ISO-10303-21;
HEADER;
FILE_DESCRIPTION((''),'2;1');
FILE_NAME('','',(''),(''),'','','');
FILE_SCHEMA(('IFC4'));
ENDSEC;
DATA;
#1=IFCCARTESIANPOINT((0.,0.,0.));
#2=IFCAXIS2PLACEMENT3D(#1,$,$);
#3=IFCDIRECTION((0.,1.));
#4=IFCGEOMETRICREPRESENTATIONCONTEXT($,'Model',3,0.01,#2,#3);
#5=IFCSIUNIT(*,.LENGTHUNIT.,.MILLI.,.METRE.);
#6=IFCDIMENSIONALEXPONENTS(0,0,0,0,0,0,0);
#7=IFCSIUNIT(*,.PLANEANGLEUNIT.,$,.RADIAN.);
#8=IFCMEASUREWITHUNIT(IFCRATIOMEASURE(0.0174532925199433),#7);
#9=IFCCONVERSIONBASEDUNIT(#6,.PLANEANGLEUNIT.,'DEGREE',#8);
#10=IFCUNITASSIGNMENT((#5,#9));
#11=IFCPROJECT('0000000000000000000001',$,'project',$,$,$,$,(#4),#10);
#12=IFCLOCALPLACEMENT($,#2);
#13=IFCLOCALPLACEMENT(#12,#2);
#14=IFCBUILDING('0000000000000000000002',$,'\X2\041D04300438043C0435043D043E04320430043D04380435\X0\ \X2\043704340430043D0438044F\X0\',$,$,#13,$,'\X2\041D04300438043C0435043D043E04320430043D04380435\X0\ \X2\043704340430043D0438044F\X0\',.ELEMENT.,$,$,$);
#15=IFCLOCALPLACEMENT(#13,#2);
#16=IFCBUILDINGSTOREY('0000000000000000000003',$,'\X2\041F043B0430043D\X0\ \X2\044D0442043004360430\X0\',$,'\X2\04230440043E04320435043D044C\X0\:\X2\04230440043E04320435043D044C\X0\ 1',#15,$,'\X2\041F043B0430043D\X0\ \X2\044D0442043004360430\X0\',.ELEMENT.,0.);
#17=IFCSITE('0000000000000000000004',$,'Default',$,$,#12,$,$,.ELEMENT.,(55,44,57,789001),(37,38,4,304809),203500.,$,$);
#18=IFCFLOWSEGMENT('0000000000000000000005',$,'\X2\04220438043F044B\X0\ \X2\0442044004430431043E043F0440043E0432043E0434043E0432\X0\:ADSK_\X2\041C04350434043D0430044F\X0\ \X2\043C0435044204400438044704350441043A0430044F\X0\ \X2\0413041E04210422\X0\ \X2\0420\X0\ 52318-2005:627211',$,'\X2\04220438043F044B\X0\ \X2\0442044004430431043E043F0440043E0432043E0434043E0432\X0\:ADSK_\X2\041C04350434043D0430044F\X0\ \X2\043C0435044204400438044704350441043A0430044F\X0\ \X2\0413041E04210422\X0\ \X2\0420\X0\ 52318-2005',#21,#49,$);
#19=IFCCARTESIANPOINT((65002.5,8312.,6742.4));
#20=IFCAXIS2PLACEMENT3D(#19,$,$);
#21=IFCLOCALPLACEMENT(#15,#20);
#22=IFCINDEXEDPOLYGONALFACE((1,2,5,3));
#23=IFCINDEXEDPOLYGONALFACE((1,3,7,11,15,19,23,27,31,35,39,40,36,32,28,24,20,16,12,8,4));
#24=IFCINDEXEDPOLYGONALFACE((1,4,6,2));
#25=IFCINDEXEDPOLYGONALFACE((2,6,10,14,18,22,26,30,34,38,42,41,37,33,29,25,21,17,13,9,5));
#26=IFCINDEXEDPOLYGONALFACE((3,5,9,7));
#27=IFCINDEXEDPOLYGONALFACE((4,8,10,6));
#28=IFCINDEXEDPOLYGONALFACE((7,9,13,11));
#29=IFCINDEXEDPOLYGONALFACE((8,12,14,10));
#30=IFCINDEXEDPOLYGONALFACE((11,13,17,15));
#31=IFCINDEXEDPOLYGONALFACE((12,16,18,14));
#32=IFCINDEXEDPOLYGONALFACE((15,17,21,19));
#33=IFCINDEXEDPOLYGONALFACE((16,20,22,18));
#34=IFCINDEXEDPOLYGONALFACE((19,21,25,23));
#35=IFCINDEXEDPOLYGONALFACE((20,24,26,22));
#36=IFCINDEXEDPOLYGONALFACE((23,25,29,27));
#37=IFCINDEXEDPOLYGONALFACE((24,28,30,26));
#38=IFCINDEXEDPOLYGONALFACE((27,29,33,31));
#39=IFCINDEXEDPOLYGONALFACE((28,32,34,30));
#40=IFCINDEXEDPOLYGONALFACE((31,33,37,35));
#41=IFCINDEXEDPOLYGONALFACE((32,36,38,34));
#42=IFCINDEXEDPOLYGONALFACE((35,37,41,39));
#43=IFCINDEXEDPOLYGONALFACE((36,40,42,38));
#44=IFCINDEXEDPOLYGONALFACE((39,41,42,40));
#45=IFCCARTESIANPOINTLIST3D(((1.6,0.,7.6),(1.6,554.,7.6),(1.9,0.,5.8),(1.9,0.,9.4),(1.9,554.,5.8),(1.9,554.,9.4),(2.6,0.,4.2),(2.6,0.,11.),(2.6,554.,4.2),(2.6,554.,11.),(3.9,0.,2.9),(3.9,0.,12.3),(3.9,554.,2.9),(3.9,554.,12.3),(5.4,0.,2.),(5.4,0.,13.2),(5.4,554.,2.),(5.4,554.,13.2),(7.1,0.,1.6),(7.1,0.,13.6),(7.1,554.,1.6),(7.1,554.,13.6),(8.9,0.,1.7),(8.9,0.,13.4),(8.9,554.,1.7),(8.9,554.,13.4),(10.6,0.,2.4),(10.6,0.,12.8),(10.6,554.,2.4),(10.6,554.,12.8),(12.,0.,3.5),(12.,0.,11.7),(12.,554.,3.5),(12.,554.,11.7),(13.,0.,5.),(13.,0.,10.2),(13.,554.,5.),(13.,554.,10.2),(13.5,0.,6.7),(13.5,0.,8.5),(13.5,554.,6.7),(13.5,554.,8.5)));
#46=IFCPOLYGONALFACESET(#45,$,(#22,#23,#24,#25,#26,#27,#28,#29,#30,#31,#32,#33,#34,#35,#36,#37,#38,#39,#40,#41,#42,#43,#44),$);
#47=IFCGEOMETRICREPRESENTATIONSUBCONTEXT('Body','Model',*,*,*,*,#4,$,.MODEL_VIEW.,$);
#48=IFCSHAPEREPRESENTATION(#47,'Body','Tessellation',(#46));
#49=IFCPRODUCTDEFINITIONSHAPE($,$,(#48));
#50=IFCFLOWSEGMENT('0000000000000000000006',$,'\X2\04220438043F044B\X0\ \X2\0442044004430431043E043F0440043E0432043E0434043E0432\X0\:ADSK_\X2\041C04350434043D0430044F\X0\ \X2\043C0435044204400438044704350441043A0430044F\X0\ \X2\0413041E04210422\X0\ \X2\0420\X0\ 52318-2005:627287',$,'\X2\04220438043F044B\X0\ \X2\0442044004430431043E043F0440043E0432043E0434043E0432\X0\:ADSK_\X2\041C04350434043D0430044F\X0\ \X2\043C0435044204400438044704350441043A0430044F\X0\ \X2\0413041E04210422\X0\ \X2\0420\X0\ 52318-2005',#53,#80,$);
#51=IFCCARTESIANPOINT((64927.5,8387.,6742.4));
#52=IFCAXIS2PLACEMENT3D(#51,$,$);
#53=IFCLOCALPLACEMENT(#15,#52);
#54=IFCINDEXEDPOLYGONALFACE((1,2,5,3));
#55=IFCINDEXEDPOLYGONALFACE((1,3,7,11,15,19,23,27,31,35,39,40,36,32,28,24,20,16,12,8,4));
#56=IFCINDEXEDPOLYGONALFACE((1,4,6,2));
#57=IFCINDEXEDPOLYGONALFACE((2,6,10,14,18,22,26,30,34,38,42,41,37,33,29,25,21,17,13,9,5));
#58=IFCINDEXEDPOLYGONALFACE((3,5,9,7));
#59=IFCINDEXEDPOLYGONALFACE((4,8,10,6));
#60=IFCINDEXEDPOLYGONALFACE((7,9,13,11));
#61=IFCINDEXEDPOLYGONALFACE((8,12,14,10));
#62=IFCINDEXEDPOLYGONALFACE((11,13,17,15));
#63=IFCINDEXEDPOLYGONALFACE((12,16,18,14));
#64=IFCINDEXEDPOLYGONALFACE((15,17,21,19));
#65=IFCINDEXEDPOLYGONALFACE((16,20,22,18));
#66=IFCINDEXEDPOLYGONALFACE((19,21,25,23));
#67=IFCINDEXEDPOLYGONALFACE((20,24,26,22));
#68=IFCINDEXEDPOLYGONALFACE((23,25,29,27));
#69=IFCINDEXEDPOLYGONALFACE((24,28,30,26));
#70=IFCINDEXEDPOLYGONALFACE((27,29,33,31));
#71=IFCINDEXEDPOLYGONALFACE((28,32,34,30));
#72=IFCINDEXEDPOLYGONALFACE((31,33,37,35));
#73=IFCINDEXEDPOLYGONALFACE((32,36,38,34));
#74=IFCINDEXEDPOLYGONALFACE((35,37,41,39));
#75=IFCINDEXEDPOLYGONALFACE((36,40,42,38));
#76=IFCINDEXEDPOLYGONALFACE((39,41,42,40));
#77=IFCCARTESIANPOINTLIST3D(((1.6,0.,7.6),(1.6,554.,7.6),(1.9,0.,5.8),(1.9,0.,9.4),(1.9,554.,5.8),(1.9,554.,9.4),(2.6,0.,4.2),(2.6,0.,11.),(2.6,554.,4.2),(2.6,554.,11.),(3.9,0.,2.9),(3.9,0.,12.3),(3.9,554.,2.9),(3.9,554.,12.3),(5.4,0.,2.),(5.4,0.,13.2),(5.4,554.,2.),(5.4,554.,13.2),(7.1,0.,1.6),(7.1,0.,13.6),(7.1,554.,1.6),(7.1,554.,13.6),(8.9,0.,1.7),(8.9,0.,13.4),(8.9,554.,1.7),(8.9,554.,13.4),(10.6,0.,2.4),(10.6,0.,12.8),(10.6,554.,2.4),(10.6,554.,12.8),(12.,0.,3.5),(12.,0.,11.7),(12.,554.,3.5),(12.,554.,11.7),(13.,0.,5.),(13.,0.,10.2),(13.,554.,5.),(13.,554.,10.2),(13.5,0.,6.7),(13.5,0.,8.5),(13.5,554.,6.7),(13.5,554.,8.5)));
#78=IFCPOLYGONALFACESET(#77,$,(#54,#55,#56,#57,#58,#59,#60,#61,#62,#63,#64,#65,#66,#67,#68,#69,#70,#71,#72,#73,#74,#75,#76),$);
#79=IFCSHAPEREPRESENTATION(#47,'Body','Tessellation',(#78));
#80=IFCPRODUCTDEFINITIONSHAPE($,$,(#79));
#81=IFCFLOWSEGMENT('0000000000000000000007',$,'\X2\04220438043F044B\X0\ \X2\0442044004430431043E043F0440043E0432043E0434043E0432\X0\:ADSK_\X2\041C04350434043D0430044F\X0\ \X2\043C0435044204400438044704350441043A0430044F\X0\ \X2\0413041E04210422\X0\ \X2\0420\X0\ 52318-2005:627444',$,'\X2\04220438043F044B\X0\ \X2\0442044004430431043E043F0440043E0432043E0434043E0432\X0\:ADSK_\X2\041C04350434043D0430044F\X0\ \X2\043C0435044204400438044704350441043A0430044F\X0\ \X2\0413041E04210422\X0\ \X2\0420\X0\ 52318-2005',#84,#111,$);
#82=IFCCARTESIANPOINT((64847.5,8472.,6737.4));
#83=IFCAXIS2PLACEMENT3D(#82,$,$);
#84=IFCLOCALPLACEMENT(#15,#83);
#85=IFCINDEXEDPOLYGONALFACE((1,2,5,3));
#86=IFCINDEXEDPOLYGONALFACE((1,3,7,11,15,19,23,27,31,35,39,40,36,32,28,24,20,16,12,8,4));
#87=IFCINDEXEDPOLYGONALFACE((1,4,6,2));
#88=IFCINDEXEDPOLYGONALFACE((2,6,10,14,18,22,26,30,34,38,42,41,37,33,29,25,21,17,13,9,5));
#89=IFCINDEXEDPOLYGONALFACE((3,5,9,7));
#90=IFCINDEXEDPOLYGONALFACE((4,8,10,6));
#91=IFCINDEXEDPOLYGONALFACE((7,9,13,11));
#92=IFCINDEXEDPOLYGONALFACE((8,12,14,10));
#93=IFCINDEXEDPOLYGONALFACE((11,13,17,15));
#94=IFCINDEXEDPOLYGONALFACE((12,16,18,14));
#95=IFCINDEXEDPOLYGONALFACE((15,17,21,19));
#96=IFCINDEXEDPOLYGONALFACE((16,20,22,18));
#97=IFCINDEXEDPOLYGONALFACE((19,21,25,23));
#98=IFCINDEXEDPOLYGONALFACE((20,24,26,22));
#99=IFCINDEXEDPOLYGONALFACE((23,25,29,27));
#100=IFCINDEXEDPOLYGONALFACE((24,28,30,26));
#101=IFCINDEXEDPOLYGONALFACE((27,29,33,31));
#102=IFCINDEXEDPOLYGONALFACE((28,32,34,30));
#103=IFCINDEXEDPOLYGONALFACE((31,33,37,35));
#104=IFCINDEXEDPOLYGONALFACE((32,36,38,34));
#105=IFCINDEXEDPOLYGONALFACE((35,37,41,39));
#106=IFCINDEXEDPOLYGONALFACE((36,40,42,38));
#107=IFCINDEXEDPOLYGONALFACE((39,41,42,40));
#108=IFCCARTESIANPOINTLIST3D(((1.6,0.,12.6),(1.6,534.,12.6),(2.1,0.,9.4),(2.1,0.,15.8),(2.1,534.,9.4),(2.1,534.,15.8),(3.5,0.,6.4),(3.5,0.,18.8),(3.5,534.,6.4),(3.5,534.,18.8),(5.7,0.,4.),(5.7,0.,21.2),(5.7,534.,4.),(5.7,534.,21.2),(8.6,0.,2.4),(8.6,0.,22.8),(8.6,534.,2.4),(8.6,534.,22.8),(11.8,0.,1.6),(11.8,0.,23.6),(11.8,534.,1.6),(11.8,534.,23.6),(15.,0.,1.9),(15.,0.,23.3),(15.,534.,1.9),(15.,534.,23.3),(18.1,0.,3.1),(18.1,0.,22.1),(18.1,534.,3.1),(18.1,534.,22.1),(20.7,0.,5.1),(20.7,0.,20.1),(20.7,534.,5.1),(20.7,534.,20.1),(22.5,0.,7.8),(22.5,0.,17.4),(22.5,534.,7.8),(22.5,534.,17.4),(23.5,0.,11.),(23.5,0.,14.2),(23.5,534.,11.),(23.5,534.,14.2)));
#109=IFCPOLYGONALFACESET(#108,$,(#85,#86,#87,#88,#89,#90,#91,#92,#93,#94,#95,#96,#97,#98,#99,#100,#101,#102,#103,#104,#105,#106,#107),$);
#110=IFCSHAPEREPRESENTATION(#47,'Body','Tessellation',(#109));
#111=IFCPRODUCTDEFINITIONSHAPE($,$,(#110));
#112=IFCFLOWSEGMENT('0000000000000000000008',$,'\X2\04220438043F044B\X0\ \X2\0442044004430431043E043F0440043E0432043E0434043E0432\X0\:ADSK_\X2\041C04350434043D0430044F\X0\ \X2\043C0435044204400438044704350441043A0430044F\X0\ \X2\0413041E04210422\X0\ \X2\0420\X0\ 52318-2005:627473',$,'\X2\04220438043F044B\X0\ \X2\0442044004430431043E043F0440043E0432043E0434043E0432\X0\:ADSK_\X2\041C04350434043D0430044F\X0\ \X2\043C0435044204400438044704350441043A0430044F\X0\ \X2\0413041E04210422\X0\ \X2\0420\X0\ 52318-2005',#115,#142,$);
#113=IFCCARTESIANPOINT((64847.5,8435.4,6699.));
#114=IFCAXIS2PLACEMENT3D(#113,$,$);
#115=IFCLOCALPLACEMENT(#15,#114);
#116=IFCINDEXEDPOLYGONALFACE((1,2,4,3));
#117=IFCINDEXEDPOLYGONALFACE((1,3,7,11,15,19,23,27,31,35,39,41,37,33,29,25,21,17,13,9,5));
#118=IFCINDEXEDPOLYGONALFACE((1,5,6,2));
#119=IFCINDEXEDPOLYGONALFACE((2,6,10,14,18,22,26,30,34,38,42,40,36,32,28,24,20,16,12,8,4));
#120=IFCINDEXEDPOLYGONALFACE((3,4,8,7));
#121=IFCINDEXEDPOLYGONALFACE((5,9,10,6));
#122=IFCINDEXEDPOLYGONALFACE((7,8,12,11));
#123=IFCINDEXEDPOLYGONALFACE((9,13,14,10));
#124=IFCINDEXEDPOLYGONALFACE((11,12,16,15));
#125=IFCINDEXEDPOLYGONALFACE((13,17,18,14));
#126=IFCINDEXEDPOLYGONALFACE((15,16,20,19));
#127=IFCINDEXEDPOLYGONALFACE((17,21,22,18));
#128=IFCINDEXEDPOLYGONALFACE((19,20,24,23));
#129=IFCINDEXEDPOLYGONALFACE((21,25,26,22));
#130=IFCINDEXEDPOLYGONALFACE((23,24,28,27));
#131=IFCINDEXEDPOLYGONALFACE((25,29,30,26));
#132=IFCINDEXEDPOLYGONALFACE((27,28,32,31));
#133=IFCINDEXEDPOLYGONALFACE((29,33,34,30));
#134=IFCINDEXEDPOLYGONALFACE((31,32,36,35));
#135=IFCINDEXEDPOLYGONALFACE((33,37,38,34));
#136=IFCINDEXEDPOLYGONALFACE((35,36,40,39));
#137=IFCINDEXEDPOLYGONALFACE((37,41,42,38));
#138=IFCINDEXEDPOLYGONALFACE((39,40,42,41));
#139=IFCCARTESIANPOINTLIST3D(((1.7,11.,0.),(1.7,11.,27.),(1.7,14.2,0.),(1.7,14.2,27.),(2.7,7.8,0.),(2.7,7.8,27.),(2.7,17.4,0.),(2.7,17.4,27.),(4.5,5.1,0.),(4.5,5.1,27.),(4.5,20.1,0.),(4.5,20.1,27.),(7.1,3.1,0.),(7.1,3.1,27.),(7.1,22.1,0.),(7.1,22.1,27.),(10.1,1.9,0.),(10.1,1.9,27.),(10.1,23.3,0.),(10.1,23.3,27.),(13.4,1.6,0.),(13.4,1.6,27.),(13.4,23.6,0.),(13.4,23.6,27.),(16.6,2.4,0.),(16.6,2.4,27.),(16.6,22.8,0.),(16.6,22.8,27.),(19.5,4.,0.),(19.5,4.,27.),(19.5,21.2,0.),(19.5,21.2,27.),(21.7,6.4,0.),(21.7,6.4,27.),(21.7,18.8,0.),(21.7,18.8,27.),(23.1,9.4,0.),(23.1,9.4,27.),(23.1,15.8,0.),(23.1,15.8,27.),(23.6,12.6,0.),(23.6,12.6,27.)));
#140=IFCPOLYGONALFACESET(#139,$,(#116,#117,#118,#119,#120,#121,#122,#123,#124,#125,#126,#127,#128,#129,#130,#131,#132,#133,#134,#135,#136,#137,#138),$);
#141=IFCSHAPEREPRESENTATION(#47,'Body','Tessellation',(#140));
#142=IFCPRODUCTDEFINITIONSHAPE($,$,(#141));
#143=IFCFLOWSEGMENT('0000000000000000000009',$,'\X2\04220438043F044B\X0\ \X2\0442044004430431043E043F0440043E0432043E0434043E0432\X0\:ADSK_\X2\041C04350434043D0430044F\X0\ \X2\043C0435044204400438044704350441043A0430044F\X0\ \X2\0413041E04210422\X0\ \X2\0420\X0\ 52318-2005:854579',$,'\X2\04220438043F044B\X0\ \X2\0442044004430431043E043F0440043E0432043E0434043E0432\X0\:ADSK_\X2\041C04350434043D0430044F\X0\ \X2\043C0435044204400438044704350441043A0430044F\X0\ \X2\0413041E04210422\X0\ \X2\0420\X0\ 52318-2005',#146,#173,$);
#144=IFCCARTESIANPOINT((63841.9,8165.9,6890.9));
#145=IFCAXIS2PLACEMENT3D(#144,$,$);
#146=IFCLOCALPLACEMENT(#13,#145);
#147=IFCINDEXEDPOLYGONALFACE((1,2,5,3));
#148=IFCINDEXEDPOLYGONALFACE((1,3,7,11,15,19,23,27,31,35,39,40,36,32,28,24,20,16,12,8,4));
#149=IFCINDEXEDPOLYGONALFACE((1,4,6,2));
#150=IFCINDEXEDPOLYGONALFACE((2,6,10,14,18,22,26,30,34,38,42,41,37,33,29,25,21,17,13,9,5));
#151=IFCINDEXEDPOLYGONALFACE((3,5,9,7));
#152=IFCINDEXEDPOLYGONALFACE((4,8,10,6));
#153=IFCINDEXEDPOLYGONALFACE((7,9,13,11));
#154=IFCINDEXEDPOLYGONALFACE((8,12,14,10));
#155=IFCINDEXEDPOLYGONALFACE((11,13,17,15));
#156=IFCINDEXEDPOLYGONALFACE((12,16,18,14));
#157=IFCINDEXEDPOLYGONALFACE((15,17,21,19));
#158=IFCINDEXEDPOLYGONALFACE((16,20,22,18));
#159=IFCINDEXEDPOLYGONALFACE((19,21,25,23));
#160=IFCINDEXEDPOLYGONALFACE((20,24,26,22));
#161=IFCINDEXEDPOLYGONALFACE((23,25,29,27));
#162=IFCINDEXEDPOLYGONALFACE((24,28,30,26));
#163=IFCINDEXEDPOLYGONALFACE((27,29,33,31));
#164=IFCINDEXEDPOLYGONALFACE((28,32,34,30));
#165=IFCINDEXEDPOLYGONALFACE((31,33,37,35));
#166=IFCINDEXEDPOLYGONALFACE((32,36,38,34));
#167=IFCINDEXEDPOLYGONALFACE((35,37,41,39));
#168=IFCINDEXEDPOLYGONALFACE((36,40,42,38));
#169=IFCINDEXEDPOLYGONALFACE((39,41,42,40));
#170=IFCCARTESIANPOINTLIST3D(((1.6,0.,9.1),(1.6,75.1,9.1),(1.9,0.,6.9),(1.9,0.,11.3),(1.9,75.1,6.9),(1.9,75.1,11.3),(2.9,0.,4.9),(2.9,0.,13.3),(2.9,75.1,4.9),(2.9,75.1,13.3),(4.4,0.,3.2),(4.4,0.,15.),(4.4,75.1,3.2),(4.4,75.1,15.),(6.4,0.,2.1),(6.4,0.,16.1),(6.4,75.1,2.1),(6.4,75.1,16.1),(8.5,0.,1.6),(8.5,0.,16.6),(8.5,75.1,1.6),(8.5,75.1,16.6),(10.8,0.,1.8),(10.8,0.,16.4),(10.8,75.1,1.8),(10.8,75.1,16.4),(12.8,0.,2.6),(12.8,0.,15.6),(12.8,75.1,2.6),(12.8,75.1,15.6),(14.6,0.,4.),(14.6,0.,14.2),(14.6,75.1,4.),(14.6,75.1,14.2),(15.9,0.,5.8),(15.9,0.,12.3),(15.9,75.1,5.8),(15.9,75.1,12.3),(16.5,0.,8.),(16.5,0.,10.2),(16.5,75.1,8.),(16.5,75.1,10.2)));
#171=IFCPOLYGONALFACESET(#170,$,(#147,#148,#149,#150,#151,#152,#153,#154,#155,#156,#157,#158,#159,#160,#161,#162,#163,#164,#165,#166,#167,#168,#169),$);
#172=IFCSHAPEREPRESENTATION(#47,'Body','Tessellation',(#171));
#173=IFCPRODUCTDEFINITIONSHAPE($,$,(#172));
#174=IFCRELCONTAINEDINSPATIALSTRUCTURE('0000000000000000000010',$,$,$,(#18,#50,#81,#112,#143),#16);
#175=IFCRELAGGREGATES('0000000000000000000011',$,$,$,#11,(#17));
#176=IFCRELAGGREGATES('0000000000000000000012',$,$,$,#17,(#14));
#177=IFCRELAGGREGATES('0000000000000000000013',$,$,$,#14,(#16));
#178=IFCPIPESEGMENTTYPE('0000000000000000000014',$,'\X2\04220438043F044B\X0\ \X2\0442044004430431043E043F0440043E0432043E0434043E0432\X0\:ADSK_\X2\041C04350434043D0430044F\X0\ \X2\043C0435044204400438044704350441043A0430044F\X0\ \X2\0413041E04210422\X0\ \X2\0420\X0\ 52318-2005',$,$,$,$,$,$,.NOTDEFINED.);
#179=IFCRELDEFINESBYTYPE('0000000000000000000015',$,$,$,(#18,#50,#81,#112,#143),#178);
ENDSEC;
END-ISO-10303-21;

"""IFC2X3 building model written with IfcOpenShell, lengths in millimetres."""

from ifc_helpers import new_model, entity, si_unit, converted_unit, direction, frame, frame_2d, origin, origin_2d_with_axis, place, context, subcontext, project, spatial, circle, extrude, type_object, element, save


model = new_model("IFC2X3")

# Units and contexts
model_context = context("Model", 3, precision=0.01, world=origin(), true_north=direction((0.0, 1.0)))
body_context = subcontext(model_context, "Body", "Model", "MODEL_VIEW")
ifc_project = project(units=[si_unit("LENGTHUNIT", "METRE", prefix="MILLI"), converted_unit("PLANEANGLEUNIT", "DEGREE", entity("IfcRatioMeasure", 0.0174532925199433), si_unit("PLANEANGLEUNIT", "RADIAN"), dimensions=[0, 0, 0, 0, 0, 0, 0])], contexts=[model_context])

# Site, building, storey
site_placement = place(None, frame((0.0, 0.0, 0.0)))
site = spatial("IfcSite", under=ifc_project, at=site_placement, Name="Default", CompositionType="ELEMENT", RefLatitude=(55, 44, 57, 789001), RefLongitude=(37, 38, 4, 304809), RefElevation=203500.0)
building_placement = place(site_placement, origin())
building = spatial("IfcBuilding", under=site, at=building_placement, Name="Наименование здания", LongName="Наименование здания", CompositionType="ELEMENT")
storey_placement = place(building_placement, origin())
storey = spatial("IfcBuildingStorey", under=building, at=storey_placement, Name="План этажа", ObjectType="Уровень:Уровень 1", LongName="План этажа", CompositionType="ELEMENT", Elevation=0.0)

# Flow segments
pipe_segment_type = type_object("IfcPipeSegmentType", Name="Типы трубопроводов:ADSK_Медная метрическая ГОСТ Р 52318-2005", PredefinedType="NOTDEFINED")
flow_segment_1_placement = place(storey_placement, frame((65002.5, 8312.0, 6742.4)))
element("IfcFlowSegment", 1, at=flow_segment_1_placement, inside=storey, type_object=pipe_segment_type, Name="Типы трубопроводов:ADSK_Медная метрическая ГОСТ Р 52318-2005:627211", ObjectType="Типы трубопроводов:ADSK_Медная метрическая ГОСТ Р 52318-2005", context=body_context, shape_type="SweptSolid", body=[
    extrude(circle(Radius=6.0, at=frame_2d((0.0, 0.0), x_axis=(1.0, 0.0))), frame((7.6, 0.0, 7.6), z_axis=(0.0, 1.0, 0.0), x_axis=(-1.0, 0.0, 0.0)), (0.0, 0.0, 1.0), 554.0),
])
flow_segment_2_placement = place(storey_placement, frame((64927.5, 8387.0, 6742.4)))
element("IfcFlowSegment", 2, at=flow_segment_2_placement, inside=storey, type_object=pipe_segment_type, Name="Типы трубопроводов:ADSK_Медная метрическая ГОСТ Р 52318-2005:627287", ObjectType="Типы трубопроводов:ADSK_Медная метрическая ГОСТ Р 52318-2005", context=body_context, shape_type="SweptSolid", body=[
    extrude(circle(Radius=6.0, at=origin_2d_with_axis()), frame((7.6, 0.0, 7.6), z_axis=(0.0, 1.0, 0.0), x_axis=(-1.0, 0.0, 0.0)), (0.0, 0.0, 1.0), 554.0),
])
flow_segment_3_placement = place(storey_placement, frame((64847.5, 8472.0, 6737.4)))
element("IfcFlowSegment", 3, at=flow_segment_3_placement, inside=storey, type_object=pipe_segment_type, Name="Типы трубопроводов:ADSK_Медная метрическая ГОСТ Р 52318-2005:627444", ObjectType="Типы трубопроводов:ADSK_Медная метрическая ГОСТ Р 52318-2005", context=body_context, shape_type="SweptSolid", body=[
    extrude(circle(Radius=11.0, at=frame_2d((0.0, 0.0), x_axis=(1.0, 0.0))), frame((12.6, 0.0, 12.6), z_axis=(0.0, 1.0, 0.0), x_axis=(-1.0, 0.0, 0.0)), (0.0, 0.0, 1.0), 534.0),
])
flow_segment_4_placement = place(storey_placement, frame((64847.5, 8435.4, 6699.0)))
element("IfcFlowSegment", 4, at=flow_segment_4_placement, inside=storey, type_object=pipe_segment_type, Name="Типы трубопроводов:ADSK_Медная метрическая ГОСТ Р 52318-2005:627473", ObjectType="Типы трубопроводов:ADSK_Медная метрическая ГОСТ Р 52318-2005", context=body_context, shape_type="SweptSolid", body=[
    extrude(circle(Radius=11.0, at=origin_2d_with_axis()), frame((12.6, 12.6, 0.0)), (0.0, 0.0, 1.0), 27.0),
])
flow_segment_5_placement = place(building_placement, frame((63841.9, 8165.9, 6890.9)))
element("IfcFlowSegment", 5, at=flow_segment_5_placement, inside=storey, type_object=pipe_segment_type, Name="Типы трубопроводов:ADSK_Медная метрическая ГОСТ Р 52318-2005:854579", ObjectType="Типы трубопроводов:ADSK_Медная метрическая ГОСТ Р 52318-2005", context=body_context, shape_type="SweptSolid", body=[
    extrude(circle(Radius=7.5, at=frame_2d((0.0, 0.0), x_axis=(1.0, 0.0))), frame((9.1, 0.0, 9.1), z_axis=(0.0, 1.0, 0.0), x_axis=(-1.0, 0.0, 0.0)), (0.0, 0.0, 1.0), 75.1),
])

save(model, "model.ifc")
